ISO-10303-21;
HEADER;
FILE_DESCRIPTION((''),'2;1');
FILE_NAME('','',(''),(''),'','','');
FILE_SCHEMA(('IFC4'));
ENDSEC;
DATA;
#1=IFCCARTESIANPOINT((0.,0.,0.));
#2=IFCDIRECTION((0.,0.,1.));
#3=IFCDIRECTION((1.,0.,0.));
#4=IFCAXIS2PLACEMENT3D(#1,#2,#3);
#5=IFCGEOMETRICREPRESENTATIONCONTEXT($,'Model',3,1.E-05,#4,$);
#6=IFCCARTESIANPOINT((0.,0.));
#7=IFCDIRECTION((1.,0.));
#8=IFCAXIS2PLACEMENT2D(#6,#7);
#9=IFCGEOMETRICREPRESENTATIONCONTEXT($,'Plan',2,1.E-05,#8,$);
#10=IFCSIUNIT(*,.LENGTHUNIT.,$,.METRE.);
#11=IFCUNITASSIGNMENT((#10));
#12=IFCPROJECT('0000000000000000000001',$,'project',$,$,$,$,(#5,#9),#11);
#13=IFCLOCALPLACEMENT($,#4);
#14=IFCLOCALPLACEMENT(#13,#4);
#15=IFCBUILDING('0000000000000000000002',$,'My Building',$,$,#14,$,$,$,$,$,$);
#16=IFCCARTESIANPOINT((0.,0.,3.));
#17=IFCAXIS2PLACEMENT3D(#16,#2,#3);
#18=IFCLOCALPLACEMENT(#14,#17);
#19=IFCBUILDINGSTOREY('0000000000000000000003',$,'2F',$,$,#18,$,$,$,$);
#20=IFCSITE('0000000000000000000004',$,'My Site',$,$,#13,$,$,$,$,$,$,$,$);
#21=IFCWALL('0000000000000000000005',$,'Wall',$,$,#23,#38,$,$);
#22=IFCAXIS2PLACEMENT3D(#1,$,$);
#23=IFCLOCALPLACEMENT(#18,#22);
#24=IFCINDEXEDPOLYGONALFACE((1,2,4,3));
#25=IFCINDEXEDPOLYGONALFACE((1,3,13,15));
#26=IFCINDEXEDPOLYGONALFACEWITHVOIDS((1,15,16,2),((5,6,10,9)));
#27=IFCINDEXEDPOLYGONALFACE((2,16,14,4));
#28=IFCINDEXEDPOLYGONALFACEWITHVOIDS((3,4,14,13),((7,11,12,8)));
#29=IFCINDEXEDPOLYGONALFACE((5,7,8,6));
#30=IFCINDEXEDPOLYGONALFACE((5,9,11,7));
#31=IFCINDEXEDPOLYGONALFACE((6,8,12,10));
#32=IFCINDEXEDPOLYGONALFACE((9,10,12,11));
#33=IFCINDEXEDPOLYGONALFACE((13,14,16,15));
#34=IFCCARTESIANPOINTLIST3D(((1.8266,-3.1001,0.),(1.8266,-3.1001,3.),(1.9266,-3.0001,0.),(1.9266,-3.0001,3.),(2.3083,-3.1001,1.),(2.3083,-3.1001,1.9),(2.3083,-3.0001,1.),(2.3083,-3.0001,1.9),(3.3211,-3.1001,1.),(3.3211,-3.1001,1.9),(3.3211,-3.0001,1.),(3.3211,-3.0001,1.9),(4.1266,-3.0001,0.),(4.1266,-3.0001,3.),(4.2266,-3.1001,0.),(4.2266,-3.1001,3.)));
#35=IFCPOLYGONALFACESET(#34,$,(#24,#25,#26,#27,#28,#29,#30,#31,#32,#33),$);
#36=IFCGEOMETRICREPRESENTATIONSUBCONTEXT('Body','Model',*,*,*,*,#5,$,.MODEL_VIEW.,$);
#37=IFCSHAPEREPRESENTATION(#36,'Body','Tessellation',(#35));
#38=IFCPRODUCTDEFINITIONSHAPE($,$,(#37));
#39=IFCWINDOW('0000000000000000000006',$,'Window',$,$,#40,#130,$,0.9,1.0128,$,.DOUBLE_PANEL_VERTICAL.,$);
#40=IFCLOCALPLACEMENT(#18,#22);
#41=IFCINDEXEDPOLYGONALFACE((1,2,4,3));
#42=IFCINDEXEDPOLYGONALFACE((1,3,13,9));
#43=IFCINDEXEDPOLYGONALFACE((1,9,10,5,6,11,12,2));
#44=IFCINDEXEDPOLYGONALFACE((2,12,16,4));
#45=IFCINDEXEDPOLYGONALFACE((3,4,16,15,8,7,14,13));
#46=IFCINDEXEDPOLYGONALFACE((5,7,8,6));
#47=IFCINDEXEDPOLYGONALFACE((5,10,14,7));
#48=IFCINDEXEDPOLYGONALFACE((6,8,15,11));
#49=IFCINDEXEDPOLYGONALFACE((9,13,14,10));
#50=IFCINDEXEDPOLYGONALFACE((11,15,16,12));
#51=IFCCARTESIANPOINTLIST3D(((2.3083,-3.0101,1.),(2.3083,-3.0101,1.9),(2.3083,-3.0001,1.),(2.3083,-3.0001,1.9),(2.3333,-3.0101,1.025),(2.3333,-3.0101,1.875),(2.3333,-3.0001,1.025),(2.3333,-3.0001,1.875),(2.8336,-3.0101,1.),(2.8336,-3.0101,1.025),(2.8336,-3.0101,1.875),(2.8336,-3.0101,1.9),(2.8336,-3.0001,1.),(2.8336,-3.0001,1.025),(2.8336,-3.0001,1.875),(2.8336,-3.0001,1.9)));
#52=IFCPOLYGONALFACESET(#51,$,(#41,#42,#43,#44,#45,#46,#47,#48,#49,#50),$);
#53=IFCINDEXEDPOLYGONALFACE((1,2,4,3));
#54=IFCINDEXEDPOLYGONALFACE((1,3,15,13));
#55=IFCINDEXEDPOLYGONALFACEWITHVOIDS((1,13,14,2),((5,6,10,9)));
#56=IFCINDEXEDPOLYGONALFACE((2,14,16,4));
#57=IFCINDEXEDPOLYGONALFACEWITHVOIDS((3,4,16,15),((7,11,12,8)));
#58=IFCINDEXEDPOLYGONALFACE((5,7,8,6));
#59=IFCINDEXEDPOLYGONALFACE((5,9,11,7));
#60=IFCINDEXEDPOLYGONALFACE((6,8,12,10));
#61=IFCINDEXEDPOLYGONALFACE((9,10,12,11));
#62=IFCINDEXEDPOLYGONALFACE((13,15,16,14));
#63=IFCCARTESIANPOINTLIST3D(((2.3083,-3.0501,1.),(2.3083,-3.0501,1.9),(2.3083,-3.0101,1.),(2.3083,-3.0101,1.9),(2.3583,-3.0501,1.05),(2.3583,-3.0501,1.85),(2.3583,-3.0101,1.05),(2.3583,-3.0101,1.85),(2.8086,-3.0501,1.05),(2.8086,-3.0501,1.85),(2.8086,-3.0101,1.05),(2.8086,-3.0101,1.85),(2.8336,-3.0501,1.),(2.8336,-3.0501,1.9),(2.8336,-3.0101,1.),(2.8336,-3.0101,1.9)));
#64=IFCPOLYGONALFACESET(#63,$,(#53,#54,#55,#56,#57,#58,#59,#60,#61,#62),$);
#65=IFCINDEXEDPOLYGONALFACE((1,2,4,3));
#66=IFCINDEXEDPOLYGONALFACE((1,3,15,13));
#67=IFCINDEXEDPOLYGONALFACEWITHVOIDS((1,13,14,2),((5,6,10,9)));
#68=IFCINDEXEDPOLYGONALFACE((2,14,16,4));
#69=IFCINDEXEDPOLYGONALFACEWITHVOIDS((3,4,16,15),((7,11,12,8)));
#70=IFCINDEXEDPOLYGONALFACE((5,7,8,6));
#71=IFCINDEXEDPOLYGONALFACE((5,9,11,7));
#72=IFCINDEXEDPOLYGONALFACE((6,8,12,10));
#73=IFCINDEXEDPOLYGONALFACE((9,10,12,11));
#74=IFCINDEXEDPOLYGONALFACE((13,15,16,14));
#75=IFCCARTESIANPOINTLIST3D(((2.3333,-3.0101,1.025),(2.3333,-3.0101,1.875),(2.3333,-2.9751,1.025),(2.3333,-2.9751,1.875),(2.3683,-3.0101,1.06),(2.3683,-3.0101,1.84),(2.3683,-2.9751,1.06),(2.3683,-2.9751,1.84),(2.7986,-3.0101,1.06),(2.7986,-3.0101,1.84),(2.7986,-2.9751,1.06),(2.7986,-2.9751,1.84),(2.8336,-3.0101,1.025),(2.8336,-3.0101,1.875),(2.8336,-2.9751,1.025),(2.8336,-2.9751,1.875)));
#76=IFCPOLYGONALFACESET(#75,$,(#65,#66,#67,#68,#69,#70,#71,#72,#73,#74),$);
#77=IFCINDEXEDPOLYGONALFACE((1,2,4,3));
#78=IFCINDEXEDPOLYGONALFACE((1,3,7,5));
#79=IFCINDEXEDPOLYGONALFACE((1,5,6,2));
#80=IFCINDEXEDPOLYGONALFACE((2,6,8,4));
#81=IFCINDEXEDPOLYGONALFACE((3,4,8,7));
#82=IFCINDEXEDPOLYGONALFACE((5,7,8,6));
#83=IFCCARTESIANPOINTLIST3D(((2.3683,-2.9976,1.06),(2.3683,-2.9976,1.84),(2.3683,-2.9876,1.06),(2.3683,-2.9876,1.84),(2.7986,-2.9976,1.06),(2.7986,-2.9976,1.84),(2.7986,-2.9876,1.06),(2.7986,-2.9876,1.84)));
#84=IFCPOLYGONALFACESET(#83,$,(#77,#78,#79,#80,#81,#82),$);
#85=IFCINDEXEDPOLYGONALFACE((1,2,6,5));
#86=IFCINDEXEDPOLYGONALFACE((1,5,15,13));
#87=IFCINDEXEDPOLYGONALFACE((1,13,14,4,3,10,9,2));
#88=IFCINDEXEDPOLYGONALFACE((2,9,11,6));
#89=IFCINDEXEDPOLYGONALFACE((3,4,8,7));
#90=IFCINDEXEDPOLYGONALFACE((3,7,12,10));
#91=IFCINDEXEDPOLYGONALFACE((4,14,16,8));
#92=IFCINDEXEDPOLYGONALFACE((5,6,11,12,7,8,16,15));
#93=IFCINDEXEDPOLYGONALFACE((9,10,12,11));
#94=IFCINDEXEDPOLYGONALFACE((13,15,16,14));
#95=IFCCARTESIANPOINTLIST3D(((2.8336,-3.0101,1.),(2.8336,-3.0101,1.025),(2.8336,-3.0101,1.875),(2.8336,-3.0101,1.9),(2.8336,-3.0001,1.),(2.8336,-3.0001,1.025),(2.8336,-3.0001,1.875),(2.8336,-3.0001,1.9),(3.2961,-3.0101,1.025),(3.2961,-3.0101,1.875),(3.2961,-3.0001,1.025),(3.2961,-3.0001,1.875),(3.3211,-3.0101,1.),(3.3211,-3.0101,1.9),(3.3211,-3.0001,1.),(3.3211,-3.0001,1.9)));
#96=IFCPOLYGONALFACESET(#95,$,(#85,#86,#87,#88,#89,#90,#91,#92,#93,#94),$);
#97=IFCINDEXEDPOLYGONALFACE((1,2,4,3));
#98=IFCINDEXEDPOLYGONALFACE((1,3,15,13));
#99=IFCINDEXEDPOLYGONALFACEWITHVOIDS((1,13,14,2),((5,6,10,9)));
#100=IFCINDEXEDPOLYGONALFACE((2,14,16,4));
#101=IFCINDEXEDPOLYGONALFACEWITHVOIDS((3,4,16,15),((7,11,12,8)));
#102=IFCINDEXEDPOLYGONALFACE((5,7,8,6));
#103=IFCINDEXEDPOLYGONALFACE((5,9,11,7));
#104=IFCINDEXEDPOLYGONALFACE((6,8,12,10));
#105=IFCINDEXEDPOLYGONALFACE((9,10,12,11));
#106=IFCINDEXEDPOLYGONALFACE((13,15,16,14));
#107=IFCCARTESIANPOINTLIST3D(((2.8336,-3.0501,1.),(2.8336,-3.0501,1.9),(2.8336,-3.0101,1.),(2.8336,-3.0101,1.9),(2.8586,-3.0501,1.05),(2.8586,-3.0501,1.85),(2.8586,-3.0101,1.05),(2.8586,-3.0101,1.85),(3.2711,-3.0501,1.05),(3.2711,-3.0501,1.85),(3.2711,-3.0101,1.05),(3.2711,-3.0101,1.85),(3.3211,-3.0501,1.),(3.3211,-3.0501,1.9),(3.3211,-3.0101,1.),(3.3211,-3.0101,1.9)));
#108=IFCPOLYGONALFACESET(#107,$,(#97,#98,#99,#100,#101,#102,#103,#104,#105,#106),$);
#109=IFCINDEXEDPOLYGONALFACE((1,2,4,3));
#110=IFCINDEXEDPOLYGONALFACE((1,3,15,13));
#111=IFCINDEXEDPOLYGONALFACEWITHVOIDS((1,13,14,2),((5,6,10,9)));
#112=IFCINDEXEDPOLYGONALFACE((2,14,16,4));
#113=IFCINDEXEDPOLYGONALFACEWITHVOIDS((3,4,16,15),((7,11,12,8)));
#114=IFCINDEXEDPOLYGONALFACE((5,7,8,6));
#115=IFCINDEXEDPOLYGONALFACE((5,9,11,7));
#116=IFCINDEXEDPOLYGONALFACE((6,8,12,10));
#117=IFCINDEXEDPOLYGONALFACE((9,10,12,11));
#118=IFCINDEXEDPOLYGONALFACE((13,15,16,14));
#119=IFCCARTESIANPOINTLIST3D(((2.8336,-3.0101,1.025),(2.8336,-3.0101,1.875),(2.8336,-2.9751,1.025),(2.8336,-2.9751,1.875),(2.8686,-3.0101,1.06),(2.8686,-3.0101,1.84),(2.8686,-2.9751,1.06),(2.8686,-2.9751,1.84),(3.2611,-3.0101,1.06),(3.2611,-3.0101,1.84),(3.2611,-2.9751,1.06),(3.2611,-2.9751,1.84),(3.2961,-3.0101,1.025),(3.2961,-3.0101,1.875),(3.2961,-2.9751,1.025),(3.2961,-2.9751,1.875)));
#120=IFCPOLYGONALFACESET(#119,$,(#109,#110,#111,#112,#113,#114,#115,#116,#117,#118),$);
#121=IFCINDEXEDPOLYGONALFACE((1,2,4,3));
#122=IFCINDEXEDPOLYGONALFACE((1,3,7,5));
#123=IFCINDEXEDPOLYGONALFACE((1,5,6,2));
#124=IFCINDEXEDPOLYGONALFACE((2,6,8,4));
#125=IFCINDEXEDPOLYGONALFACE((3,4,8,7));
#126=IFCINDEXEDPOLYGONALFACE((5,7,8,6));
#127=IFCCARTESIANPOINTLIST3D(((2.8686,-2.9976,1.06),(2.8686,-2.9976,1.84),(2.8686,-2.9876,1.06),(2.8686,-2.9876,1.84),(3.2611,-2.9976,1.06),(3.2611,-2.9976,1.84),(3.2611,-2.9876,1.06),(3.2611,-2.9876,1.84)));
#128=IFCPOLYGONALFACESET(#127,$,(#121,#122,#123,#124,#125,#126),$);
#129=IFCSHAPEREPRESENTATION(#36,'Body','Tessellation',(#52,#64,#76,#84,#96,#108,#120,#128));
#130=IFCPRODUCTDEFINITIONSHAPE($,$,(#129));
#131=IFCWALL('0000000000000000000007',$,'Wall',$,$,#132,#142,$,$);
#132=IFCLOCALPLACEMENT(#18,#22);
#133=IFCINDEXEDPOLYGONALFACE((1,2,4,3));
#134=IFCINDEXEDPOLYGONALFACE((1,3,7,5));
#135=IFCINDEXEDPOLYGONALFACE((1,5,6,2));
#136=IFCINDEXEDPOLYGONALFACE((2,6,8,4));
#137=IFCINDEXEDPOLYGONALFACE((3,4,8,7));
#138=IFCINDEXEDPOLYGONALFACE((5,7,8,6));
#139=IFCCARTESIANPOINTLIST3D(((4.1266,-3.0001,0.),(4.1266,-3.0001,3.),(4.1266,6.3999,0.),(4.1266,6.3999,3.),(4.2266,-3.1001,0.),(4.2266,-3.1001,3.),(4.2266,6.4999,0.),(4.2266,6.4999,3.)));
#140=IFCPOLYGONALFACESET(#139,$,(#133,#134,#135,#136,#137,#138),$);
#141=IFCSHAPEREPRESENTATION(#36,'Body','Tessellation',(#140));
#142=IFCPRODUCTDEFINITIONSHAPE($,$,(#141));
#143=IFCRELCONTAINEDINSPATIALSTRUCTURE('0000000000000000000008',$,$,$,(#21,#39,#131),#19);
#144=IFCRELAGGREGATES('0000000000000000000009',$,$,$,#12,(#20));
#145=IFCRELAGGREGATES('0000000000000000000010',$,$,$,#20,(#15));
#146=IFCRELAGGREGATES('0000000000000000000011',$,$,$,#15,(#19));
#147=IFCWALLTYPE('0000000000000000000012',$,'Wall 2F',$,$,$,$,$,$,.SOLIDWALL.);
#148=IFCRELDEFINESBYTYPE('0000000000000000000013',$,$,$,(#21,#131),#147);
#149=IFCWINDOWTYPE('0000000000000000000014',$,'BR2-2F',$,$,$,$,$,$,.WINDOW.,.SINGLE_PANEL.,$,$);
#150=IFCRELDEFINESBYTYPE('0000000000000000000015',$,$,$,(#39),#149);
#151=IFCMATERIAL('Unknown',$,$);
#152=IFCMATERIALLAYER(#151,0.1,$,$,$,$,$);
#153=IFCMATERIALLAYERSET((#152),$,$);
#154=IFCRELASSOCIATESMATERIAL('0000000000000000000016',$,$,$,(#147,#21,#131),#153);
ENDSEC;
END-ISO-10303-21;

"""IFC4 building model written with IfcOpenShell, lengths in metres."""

from ifc_helpers import new_model, entity, si_unit, frame, origin_with_axes, origin_2d_with_axis, place, context, subcontext, project, spatial, line, indexed_curve, outline, extrude, shape, source, transform, mapped, material, layer, layer_set, layer_usage, type_object, type_shapes, element, fill, save


model = new_model("IFC4")

# Units and contexts
model_context = context("Model", 3, precision=1e-05, world=origin_with_axes())
plan_context = context("Plan", 2, precision=1e-05, world=origin_2d_with_axis())
body_context_1 = subcontext(model_context, "Body", "Model", "MODEL_VIEW")
body_context_2 = subcontext(plan_context, "Body", "Plan", "PLAN_VIEW")
ifc_project = project(units=[si_unit("LENGTHUNIT", "METRE")], contexts=[model_context, plan_context])

# Site, building, storey
site_placement = place(None, origin_with_axes())
site = spatial("IfcSite", under=ifc_project, at=site_placement, Name="My Site")
building_placement = place(site_placement, origin_with_axes())
building = spatial("IfcBuilding", under=site, at=building_placement, Name="My Building")
storey_placement = place(building_placement, frame((0.0, 0.0, 3.0), z_axis=(0.0, 0.0, 1.0), x_axis=(1.0, 0.0, 0.0)))
storey = spatial("IfcBuildingStorey", under=building, at=storey_placement, Name="2F")

# Shared definitions
ifc_material = material(Name="Unknown")
ifc_layer_1 = layer(ifc_material, 0.1)
ifc_layer_set_1 = layer_set([ifc_layer_1])
wall_type_1 = type_object("IfcWallType", Name="Wall 2F", PredefinedType="SOLIDWALL", material=ifc_layer_set_1)

# Wall, opening, window
ifc_layer_usage_1 = layer_usage(ifc_layer_set_1, "AXIS2", "POSITIVE", 0.0)
wall_1_placement = place(storey_placement, frame((1.8266, -3.1001, 0.0), z_axis=(0.0, 0.0, 1.0), x_axis=(1.0, 0.0, 0.0)))
wall_1 = element("IfcWall", 1, at=wall_1_placement, inside=storey, type_object=wall_type_1, material=ifc_layer_usage_1, Name="Wall", context=body_context_1, shape_type="SweptSolid", body=[
    extrude(outline(indexed_curve([(0.0, 0.0), (0.1, 0.1), (2.3, 0.1), (2.4, 0.0)], segments=[line(1, 2, 3, 4, 1)])), origin_with_axes(), (0.0, 0.0, 1.0), 3.0),
])
shared_shape_1 = source(origin_with_axes(), body_context_1, "Body", "SweptSolid", [
    extrude(outline(indexed_curve([(0.0, 0.0), (1.0128, 0.0), (1.0128, 0.9), (0.0, 0.9)], segments=[line(1, 2, 3, 4, 1)])), frame((0.0, -0.6, 0.0), z_axis=(0.0, -1.0, 0.0), x_axis=(1.0, 0.0, 0.0)), (0.0, 0.0, -1.0), 1.2),
])
opening_1_placement = place(wall_1_placement, frame((0.4817, 0.0, 1.0), z_axis=(0.0, 0.0, 1.0), x_axis=(1.0, 0.0, 0.0)))
opening_1 = element("IfcOpeningElement", 2, at=opening_1_placement, cuts=wall_1, PredefinedType="OPENING", context=body_context_1, shape_type="MappedRepresentation", body=[
    mapped(shared_shape_1, transform((0.0, 0.0, 0.0), x_axis=(1.0, 0.0, 0.0), y_axis=(0.0, 1.0, 0.0), z_axis=(0.0, 0.0, 1.0), scale=1.0)),
])
window_type_1 = type_object("IfcWindowType", Name="BR2-2F", PartitioningType="SINGLE_PANEL", PredefinedType="WINDOW")
shared_shape_2 = source(origin_with_axes(), body_context_1, "Body", "SweptSolid", [
    extrude(outline(indexed_curve([(0.5254, 0.0), (0.0, 0.0), (0.0, 0.9), (0.5254, 0.9), (0.5254, 0.875), (0.025, 0.875), (0.025, 0.025), (0.5254, 0.025)], segments=[line(1, 2, 3, 4, 5, 6, 7, 8, 1)])), frame((0.0, 0.09, 0.0), z_axis=(0.0, -1.0, 0.0), x_axis=(1.0, 0.0, 0.0)), (0.0, 0.0, -1.0), 0.01),
    extrude(outline(indexed_curve([(0.0, 0.0), (0.5254, 0.0), (0.5254, 0.9), (0.0, 0.9)], segments=[line(1, 2, 3, 4, 1)]), holes=[indexed_curve([(0.05, 0.05), (0.5004, 0.05), (0.5004, 0.85), (0.05, 0.85)], segments=[line(1, 2, 3, 4, 1)])]), frame((0.0, 0.05, 0.0), z_axis=(0.0, -1.0, 0.0), x_axis=(1.0, 0.0, 0.0)), (0.0, 0.0, -1.0), 0.04),
    extrude(outline(indexed_curve([(0.0, 0.0), (0.5004, 0.0), (0.5004, 0.85), (0.0, 0.85)], segments=[line(1, 2, 3, 4, 1)]), holes=[indexed_curve([(0.035, 0.035), (0.4654, 0.035), (0.4654, 0.815), (0.035, 0.815)], segments=[line(1, 2, 3, 4, 1)])]), frame((0.025, 0.09, 0.025), z_axis=(0.0, -1.0, 0.0), x_axis=(1.0, 0.0, 0.0)), (0.0, 0.0, -1.0), 0.035),
    extrude(outline(indexed_curve([(0.035, 0.035), (0.4654, 0.035), (0.4654, 0.815), (0.035, 0.815)], segments=[line(1, 2, 3, 4, 1)])), frame((0.025, 0.1025, 0.025), z_axis=(0.0, -1.0, 0.0), x_axis=(1.0, 0.0, 0.0)), (0.0, 0.0, -1.0), 0.01),
    extrude(outline(indexed_curve([(0.0, 0.9), (0.4875, 0.9), (0.4875, 0.0), (0.0, 0.0), (0.0, 0.025), (0.4625, 0.025), (0.4625, 0.875), (0.0, 0.875)], segments=[line(1, 2, 3, 4, 5, 6, 7, 8, 1)])), frame((0.5254, 0.09, 0.0), z_axis=(0.0, -1.0, 0.0), x_axis=(1.0, 0.0, 0.0)), (0.0, 0.0, -1.0), 0.01),
    extrude(outline(indexed_curve([(0.0, 0.0), (0.4875, 0.0), (0.4875, 0.9), (0.0, 0.9)], segments=[line(1, 2, 3, 4, 1)]), holes=[indexed_curve([(0.025, 0.05), (0.4375, 0.05), (0.4375, 0.85), (0.025, 0.85)], segments=[line(1, 2, 3, 4, 1)])]), frame((0.5254, 0.05, 0.0), z_axis=(0.0, -1.0, 0.0), x_axis=(1.0, 0.0, 0.0)), (0.0, 0.0, -1.0), 0.04),
    extrude(outline(indexed_curve([(0.0, 0.0), (0.4625, 0.0), (0.4625, 0.85), (0.0, 0.85)], segments=[line(1, 2, 3, 4, 1)]), holes=[indexed_curve([(0.035, 0.035), (0.4275, 0.035), (0.4275, 0.815), (0.035, 0.815)], segments=[line(1, 2, 3, 4, 1)])]), frame((0.5254, 0.09, 0.025), z_axis=(0.0, -1.0, 0.0), x_axis=(1.0, 0.0, 0.0)), (0.0, 0.0, -1.0), 0.035),
    extrude(outline(indexed_curve([(0.035, 0.035), (0.4275, 0.035), (0.4275, 0.815), (0.035, 0.815)], segments=[line(1, 2, 3, 4, 1)])), frame((0.5254, 0.1025, 0.025), z_axis=(0.0, -1.0, 0.0), x_axis=(1.0, 0.0, 0.0)), (0.0, 0.0, -1.0), 0.01),
])
shared_shape_3 = source(origin_with_axes(), body_context_2, "Body", "Curve2D", [
    entity("IfcIndexedPolyCurve", entity("IfcCartesianPointList2D", [[0.05, 0.05], [0.5004, 0.05]])),
    entity("IfcIndexedPolyCurve", entity("IfcCartesianPointList2D", [[0.0, 0.1], [0.025, 0.1], [0.025, 0.09], [0.05, 0.09], [0.05, 0.05], [0.0, 0.05]]), [entity("IfcLineIndex", [1, 2, 3, 4, 5, 6, 1])]),
    entity("IfcIndexedPolyCurve", entity("IfcCartesianPointList2D", [[0.5254, 0.1], [0.5254, 0.1], [0.5254, 0.09], [0.5004, 0.09], [0.5004, 0.05], [0.5254, 0.05]])),
    entity("IfcIndexedPolyCurve", entity("IfcCartesianPointList2D", [[0.025, 0.09], [0.06, 0.09], [0.06, 0.125], [0.025, 0.125]]), [entity("IfcLineIndex", [1, 2, 3, 4, 1])]),
    entity("IfcIndexedPolyCurve", entity("IfcCartesianPointList2D", [[0.5254, 0.09], [0.4904, 0.09], [0.4904, 0.125], [0.5254, 0.125]]), [entity("IfcLineIndex", [1, 2, 3, 4, 1])]),
    entity("IfcIndexedPolyCurve", entity("IfcCartesianPointList2D", [[0.06, 0.09], [0.4904, 0.09]])),
    entity("IfcIndexedPolyCurve", entity("IfcCartesianPointList2D", [[0.06, 0.125], [0.4904, 0.125]])),
    entity("IfcIndexedPolyCurve", entity("IfcCartesianPointList2D", [[0.06, 0.1075], [0.4904, 0.1075]])),
    entity("IfcIndexedPolyCurve", entity("IfcCartesianPointList2D", [[0.5504, 0.05], [0.9628, 0.05]])),
    entity("IfcIndexedPolyCurve", entity("IfcCartesianPointList2D", [[0.5254, 0.1], [0.5254, 0.1], [0.5254, 0.09], [0.5504, 0.09], [0.5504, 0.05], [0.5254, 0.05]])),
    entity("IfcIndexedPolyCurve", entity("IfcCartesianPointList2D", [[1.0128, 0.1], [0.9878, 0.1], [0.9878, 0.09], [0.9628, 0.09], [0.9628, 0.05], [1.0128, 0.05]]), [entity("IfcLineIndex", [1, 2, 3, 4, 5, 6, 1])]),
    entity("IfcIndexedPolyCurve", entity("IfcCartesianPointList2D", [[0.5254, 0.09], [0.5604, 0.09], [0.5604, 0.125], [0.5254, 0.125]]), [entity("IfcLineIndex", [1, 2, 3, 4, 1])]),
    entity("IfcIndexedPolyCurve", entity("IfcCartesianPointList2D", [[0.9878, 0.09], [0.9528, 0.09], [0.9528, 0.125], [0.9878, 0.125]]), [entity("IfcLineIndex", [1, 2, 3, 4, 1])]),
    entity("IfcIndexedPolyCurve", entity("IfcCartesianPointList2D", [[0.5604, 0.09], [0.9528, 0.09]])),
    entity("IfcIndexedPolyCurve", entity("IfcCartesianPointList2D", [[0.5604, 0.125], [0.9528, 0.125]])),
    entity("IfcIndexedPolyCurve", entity("IfcCartesianPointList2D", [[0.5604, 0.1075], [0.9528, 0.1075]])),
])
type_shapes(window_type_1, [shared_shape_2, shared_shape_3])
window_1_placement = place(opening_1_placement, frame((0.0, 0.0, 0.0), z_axis=(0.0, 0.0, 1.0), x_axis=(1.0, 0.0, 0.0)))
window_1 = element("IfcWindow", 3, at=window_1_placement, inside=storey, type_object=window_type_1, Name="Window", OverallHeight=0.9, OverallWidth=1.0128, PartitioningType="DOUBLE_PANEL_VERTICAL", shapes=[
    shape(body_context_1, "Body", "MappedRepresentation", [mapped(shared_shape_2, transform((0.0, 0.0, 0.0), x_axis=(1.0, 0.0, 0.0), y_axis=(0.0, 1.0, 0.0), z_axis=(0.0, 0.0, 1.0), scale=1.0))]),
    shape(body_context_2, "Body", "MappedRepresentation", [mapped(shared_shape_3, transform((0.0, 0.0, 0.0), x_axis=(1.0, 0.0, 0.0), y_axis=(0.0, 1.0, 0.0), z_axis=(0.0, 0.0, 1.0), scale=1.0))]),
])
fill(opening_1, window_1)

# Wall
ifc_layer_usage_2 = layer_usage(ifc_layer_set_1, "AXIS2", "POSITIVE", 0.0)
wall_2_placement = place(storey_placement, frame((4.2266, -3.1001, 0.0), z_axis=(0.0, 0.0, 1.0), x_axis=(0.0, 1.0, 0.0)))
element("IfcWall", 4, at=wall_2_placement, inside=storey, type_object=wall_type_1, material=ifc_layer_usage_2, Name="Wall", context=body_context_1, shape_type="SweptSolid", body=[
    extrude(outline(indexed_curve([(0.0, 0.0), (0.1, 0.1), (9.5, 0.1), (9.6, 0.0)], segments=[line(1, 2, 3, 4, 1)])), origin_with_axes(), (0.0, 0.0, 1.0), 3.0),
])

save(model, "model.ifc")
